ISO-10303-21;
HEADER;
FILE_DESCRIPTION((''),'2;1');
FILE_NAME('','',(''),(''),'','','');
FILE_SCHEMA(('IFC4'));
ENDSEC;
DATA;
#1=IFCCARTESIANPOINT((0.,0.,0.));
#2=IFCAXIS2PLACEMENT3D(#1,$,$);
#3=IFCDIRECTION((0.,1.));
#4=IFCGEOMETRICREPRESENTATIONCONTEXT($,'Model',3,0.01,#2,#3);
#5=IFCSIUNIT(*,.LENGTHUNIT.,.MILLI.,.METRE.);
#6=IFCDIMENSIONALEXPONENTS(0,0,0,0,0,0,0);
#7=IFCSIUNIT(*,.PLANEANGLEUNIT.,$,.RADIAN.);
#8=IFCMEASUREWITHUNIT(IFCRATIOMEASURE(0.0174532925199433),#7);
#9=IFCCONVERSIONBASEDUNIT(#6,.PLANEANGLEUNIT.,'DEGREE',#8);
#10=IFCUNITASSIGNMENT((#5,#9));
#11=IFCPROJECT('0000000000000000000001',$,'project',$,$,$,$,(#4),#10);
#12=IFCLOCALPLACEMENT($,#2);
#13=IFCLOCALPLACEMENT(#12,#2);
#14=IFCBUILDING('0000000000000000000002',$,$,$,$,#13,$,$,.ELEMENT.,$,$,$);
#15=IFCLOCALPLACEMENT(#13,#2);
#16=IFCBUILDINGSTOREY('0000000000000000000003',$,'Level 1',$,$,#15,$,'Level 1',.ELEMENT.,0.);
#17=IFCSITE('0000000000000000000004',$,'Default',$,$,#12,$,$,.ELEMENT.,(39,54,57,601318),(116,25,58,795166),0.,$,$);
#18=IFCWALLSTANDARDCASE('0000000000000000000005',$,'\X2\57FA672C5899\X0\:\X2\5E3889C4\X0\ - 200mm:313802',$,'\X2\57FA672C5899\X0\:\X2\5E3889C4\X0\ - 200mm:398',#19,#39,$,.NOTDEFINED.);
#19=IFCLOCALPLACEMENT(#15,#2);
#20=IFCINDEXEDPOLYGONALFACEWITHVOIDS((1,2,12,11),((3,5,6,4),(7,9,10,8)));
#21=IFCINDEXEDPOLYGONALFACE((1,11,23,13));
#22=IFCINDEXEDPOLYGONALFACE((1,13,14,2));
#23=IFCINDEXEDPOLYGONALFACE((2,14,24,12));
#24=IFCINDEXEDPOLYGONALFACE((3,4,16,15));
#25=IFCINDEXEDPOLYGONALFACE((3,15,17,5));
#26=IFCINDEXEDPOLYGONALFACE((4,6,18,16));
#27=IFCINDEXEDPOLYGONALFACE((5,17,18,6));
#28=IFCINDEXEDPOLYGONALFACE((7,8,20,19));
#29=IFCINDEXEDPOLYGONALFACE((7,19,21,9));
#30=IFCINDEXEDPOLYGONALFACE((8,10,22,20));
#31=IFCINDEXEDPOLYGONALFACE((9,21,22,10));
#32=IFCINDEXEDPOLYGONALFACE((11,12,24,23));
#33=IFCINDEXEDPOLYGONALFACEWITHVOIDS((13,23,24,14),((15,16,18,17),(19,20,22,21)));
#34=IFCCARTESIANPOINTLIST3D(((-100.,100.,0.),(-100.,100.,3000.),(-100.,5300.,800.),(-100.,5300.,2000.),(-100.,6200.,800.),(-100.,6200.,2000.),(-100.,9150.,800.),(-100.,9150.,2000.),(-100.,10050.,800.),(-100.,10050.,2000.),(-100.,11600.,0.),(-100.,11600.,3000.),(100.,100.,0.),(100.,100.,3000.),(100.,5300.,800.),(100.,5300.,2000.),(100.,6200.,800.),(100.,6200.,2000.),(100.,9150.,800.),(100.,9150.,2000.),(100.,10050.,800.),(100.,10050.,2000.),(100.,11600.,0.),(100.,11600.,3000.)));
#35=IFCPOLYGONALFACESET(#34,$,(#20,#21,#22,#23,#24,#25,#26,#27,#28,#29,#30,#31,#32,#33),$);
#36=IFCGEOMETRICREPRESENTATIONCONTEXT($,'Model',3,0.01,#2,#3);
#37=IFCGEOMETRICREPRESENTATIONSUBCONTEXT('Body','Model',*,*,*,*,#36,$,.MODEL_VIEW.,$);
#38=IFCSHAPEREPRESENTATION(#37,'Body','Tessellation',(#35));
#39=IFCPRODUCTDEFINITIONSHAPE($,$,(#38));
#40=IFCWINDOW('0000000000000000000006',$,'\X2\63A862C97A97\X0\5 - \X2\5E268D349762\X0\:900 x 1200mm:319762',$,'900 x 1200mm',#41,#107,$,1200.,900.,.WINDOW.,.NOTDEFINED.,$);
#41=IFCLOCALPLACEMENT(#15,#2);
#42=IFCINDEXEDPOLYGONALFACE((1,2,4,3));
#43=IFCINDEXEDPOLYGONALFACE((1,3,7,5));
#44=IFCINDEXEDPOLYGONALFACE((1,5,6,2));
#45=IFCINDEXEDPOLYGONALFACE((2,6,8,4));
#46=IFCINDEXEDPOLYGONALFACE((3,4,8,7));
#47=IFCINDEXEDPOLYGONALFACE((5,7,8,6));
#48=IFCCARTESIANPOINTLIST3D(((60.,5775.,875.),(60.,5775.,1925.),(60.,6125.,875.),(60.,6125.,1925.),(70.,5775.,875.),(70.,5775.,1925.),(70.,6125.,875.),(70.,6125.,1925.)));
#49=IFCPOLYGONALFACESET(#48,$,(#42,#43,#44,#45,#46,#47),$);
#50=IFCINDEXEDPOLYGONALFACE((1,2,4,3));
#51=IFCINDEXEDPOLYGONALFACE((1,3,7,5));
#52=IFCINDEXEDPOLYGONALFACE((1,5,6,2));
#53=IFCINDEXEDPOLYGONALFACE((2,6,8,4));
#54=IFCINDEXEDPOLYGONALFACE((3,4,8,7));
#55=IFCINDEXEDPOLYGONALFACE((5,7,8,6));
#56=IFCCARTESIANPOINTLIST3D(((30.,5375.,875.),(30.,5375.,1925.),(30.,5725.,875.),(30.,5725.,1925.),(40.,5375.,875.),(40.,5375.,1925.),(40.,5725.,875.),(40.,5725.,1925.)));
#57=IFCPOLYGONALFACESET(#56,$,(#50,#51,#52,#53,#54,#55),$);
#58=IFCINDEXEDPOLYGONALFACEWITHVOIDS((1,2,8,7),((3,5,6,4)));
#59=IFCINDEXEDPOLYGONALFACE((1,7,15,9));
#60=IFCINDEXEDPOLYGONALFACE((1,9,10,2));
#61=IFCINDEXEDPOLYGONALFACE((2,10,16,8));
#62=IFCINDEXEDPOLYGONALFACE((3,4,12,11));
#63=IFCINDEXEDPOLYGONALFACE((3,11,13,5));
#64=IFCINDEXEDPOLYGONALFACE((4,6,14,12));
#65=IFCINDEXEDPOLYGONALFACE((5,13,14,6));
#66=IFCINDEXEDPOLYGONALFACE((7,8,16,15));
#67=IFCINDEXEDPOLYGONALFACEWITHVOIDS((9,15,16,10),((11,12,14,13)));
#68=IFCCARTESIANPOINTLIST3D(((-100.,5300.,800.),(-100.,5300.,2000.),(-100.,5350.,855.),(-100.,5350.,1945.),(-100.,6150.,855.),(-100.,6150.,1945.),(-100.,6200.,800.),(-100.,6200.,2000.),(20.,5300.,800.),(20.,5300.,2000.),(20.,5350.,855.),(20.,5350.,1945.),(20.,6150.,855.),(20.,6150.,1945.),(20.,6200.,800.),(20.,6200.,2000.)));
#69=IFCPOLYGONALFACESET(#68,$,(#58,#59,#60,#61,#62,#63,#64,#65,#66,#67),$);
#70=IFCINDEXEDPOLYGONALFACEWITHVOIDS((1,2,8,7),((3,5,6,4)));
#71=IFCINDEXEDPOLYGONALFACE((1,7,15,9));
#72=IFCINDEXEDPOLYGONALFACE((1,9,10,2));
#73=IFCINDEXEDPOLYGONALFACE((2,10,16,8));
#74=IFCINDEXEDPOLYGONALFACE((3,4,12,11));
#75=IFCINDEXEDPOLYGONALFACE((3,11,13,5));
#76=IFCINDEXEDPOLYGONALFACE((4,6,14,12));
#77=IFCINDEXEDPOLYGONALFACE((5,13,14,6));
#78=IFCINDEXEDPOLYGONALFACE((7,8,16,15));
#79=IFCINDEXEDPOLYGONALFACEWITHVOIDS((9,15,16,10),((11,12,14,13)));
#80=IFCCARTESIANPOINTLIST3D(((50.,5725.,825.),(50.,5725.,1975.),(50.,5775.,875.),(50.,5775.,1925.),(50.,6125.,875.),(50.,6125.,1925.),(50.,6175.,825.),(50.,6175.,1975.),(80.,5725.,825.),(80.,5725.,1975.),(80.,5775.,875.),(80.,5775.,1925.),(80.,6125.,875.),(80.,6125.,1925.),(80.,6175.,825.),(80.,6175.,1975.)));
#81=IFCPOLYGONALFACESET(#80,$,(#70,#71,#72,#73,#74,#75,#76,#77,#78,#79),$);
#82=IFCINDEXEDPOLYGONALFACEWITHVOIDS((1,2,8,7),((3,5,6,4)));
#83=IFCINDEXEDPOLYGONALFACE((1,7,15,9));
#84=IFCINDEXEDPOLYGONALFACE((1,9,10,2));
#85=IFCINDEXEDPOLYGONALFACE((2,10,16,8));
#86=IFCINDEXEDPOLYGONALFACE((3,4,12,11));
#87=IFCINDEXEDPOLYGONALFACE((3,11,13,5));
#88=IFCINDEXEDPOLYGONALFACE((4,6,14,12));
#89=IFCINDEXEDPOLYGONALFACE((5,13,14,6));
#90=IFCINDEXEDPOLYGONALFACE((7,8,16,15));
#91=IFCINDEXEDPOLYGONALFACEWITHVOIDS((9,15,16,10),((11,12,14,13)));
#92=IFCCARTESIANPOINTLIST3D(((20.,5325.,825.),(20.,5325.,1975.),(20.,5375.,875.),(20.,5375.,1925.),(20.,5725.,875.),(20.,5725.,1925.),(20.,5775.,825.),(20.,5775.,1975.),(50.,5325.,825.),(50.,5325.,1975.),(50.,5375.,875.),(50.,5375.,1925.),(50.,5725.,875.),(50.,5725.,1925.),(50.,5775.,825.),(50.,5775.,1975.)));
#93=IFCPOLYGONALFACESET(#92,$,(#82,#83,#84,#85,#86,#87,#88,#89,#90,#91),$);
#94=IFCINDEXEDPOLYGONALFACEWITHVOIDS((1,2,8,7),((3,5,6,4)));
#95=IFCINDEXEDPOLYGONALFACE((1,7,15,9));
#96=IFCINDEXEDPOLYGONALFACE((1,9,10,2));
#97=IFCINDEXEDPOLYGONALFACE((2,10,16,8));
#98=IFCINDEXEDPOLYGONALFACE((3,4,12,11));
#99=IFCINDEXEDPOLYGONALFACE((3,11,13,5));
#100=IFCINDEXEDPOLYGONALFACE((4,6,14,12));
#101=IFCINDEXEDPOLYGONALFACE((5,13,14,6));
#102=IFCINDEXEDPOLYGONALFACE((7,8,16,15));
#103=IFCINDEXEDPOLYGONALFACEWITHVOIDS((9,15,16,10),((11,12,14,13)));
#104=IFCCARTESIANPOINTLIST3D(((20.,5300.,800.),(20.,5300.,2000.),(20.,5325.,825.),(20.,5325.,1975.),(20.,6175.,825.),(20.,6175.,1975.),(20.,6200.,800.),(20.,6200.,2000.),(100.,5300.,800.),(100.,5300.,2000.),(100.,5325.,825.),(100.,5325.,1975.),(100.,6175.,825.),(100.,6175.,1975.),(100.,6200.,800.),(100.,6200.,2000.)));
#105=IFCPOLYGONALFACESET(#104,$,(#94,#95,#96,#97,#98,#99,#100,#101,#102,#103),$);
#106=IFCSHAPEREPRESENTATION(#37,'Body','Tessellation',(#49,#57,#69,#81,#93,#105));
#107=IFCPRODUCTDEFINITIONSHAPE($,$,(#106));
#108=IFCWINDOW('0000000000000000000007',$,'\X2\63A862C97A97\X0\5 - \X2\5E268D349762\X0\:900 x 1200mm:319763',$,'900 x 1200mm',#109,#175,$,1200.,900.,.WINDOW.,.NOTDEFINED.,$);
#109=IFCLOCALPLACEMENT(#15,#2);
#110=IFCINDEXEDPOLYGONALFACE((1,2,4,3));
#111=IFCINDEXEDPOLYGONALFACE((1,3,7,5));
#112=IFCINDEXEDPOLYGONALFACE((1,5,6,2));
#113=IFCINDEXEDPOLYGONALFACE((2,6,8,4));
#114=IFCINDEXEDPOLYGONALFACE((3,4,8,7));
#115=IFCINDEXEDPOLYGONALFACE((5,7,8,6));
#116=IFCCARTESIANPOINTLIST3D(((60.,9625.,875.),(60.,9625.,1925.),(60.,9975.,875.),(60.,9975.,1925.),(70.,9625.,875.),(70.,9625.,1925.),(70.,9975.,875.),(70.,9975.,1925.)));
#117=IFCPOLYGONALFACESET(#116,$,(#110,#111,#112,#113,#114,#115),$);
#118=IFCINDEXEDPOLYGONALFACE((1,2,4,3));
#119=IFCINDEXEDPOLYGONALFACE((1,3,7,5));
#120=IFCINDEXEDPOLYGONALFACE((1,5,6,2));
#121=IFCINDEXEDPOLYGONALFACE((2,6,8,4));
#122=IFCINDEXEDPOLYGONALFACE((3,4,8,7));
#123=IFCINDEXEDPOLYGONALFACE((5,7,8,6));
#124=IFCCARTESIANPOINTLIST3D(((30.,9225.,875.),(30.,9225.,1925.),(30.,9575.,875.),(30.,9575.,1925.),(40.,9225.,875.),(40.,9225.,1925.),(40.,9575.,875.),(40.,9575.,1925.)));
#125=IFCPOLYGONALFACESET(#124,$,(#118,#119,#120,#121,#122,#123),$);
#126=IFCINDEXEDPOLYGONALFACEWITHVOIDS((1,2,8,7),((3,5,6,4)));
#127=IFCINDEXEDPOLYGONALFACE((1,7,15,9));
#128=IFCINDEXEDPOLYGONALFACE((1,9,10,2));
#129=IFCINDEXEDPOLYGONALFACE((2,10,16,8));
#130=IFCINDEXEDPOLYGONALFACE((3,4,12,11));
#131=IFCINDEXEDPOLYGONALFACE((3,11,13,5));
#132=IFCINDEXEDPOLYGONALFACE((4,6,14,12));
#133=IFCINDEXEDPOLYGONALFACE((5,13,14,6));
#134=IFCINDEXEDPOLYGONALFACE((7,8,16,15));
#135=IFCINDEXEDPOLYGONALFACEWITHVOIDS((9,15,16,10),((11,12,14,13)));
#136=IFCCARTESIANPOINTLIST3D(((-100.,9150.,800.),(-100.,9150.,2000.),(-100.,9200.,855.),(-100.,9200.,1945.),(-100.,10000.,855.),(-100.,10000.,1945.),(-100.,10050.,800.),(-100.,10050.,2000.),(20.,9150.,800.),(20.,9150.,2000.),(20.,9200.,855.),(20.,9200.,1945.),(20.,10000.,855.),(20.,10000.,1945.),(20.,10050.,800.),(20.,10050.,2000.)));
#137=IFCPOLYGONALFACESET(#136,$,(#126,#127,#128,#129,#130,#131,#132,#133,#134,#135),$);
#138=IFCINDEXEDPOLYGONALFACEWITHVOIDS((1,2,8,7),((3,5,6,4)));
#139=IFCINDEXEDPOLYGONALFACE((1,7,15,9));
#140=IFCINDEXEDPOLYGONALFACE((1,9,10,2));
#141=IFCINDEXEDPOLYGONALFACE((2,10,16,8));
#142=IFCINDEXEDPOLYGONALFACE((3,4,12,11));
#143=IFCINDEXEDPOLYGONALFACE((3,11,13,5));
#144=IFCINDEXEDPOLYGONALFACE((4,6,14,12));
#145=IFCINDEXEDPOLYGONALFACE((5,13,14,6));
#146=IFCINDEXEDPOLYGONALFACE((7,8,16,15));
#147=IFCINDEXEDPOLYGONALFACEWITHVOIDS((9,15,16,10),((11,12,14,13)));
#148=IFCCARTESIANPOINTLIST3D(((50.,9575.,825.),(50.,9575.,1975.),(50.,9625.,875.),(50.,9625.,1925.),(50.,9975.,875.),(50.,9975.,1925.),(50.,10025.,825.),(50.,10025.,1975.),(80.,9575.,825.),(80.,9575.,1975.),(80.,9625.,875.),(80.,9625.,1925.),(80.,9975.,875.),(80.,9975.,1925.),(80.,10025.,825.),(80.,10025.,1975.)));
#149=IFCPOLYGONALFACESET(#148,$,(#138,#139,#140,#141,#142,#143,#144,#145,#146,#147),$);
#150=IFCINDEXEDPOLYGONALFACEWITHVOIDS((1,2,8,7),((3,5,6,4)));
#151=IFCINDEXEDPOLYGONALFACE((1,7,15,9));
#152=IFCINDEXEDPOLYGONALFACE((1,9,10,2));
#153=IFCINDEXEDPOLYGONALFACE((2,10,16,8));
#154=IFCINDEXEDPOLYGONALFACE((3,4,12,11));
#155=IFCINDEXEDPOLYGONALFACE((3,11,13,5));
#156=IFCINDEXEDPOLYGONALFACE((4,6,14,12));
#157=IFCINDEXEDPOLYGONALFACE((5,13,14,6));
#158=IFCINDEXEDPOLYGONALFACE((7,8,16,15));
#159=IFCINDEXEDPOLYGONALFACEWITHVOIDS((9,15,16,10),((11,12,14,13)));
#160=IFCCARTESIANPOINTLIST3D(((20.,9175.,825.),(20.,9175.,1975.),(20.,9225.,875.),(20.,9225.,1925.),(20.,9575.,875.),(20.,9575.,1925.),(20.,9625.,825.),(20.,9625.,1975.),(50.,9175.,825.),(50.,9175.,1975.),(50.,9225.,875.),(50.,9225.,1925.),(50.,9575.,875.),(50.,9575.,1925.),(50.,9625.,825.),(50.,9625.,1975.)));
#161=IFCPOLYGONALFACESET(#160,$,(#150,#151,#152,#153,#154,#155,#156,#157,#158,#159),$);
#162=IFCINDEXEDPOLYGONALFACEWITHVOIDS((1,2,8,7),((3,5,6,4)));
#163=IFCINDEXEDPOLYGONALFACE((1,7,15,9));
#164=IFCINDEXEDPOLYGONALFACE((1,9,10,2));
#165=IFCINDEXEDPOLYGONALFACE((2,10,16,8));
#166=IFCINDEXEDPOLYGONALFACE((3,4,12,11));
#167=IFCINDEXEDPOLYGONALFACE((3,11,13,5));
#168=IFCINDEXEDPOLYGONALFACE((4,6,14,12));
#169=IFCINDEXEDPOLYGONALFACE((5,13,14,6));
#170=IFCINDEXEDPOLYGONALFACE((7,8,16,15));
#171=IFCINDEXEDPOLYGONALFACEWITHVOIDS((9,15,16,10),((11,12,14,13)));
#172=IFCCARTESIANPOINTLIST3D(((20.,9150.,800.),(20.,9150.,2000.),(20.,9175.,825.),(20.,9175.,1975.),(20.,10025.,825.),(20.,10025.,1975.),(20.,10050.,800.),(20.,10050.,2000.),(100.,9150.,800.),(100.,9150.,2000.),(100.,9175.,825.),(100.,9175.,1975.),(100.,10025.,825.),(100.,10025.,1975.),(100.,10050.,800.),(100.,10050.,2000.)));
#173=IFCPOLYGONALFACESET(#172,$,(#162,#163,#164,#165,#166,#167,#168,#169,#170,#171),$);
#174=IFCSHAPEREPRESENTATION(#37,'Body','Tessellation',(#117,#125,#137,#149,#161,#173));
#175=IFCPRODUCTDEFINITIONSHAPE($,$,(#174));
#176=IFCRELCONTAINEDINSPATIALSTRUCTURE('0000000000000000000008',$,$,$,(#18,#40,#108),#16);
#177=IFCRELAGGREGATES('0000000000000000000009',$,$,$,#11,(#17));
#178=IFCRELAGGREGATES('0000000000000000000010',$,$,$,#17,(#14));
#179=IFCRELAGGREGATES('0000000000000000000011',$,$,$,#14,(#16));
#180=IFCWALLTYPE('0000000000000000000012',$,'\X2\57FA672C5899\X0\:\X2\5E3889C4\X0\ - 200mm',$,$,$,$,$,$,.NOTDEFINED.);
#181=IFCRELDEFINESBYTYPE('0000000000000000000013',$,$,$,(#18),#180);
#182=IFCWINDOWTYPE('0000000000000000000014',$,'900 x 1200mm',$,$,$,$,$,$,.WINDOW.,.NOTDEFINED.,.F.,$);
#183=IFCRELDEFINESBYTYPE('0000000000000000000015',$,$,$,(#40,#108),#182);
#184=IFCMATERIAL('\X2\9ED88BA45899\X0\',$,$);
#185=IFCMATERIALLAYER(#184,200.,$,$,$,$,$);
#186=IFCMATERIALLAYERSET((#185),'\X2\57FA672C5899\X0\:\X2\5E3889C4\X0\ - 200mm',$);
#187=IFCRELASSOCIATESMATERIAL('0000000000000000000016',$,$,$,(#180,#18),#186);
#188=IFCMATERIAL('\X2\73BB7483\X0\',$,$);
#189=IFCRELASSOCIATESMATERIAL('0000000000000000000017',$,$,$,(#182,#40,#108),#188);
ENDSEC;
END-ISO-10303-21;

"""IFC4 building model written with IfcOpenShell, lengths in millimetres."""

from ifc_helpers import new_model, entity, si_unit, converted_unit, direction, frame, frame_2d, origin, origin_2d_with_axis, place, context, subcontext, project, spatial, polyline, rectangle, outline, extrude, source, transform, mapped, material, layer, layer_set, layer_usage, type_object, type_shapes, element, fill, save


model = new_model("IFC4")

# Units and contexts
model_context_1 = context("Model", 3, precision=0.01, world=origin(), true_north=direction((0.0, 1.0)))
model_context_2 = context("Model", 3, precision=0.01, world=origin(), true_north=direction((0.0, 1.0)))
body_context = subcontext(model_context_2, "Body", "Model", "MODEL_VIEW")
ifc_project = project(units=[si_unit("LENGTHUNIT", "METRE", prefix="MILLI"), converted_unit("PLANEANGLEUNIT", "DEGREE", entity("IfcRatioMeasure", 0.0174532925199433), si_unit("PLANEANGLEUNIT", "RADIAN"), dimensions=[0, 0, 0, 0, 0, 0, 0])], contexts=[model_context_1])

# Site, building, storey
site_placement = place(None, origin())
site = spatial("IfcSite", under=ifc_project, at=site_placement, Name="Default", CompositionType="ELEMENT", RefLatitude=(39, 54, 57, 601318), RefLongitude=(116, 25, 58, 795166), RefElevation=0.0)
building_placement = place(site_placement, origin())
building = spatial("IfcBuilding", under=site, at=building_placement, CompositionType="ELEMENT")
storey_placement = place(building_placement, origin())
storey = spatial("IfcBuildingStorey", under=building, at=storey_placement, Name="Level 1", LongName="Level 1", CompositionType="ELEMENT", Elevation=0.0)

# Shared definitions
ifc_material_1 = material(Name="默认墙")
ifc_layer = layer(ifc_material_1, 200.0)
ifc_layer_set = layer_set([ifc_layer], Name="基本墙:常规 - 200mm")
wall_type = type_object("IfcWallType", Name="基本墙:常规 - 200mm", PredefinedType="NOTDEFINED", material=ifc_layer_set)
ifc_material_2 = material(Name="玻璃")

# Wall, openings, windows
ifc_layer_usage_1 = layer_usage(ifc_layer_set, "AXIS2", "NEGATIVE", 100.0)
wall_1_placement = place(storey_placement, frame((0.0, 100.0, 0.0), z_axis=(0.0, 0.0, 1.0), x_axis=(0.0, 1.0, 0.0)))
wall_1 = element("IfcWallStandardCase", 1, at=wall_1_placement, inside=storey, type_object=wall_type, material=ifc_layer_usage_1, Name="基本墙:常规 - 200mm:313802", ObjectType="基本墙:常规 - 200mm:398", PredefinedType="NOTDEFINED", context=body_context, shape_type="SweptSolid", body=[
    extrude(rectangle(XDim=11500.0, YDim=200.0, at=frame_2d((5750.0, 0.0), x_axis=(-1.0, 0.0))), origin(), (0.0, 0.0, 1.0), 3000.0),
])
opening_1_placement = place(wall_1_placement, frame((6100.0, 100.0, 800.0)))
opening_1 = element("IfcOpeningElement", 2, at=opening_1_placement, cuts=wall_1, ObjectType="Opening", PredefinedType="OPENING", context=body_context, shape_type="SweptSolid", body=[
    extrude(rectangle(XDim=1200.0, YDim=900.0, at=frame_2d((600.0, 450.0), x_axis=(-1.0, 0.0))), frame((0.0, 0.0, 0.0), z_axis=(0.0, -1.0, 0.0), x_axis=(0.0, 0.0, 1.0)), (0.0, 0.0, 1.0), 200.0),
])
opening_2_placement = place(wall_1_placement, frame((9950.0, 100.0, 800.0)))
opening_2 = element("IfcOpeningElement", 3, at=opening_2_placement, cuts=wall_1, ObjectType="Opening", PredefinedType="OPENING", context=body_context, shape_type="SweptSolid", body=[
    extrude(rectangle(XDim=1200.0, YDim=900.0, at=frame_2d((600.0, 450.0), x_axis=(-1.0, 0.0))), frame((0.0, 0.0, 0.0), z_axis=(0.0, -1.0, 0.0), x_axis=(0.0, 0.0, 1.0)), (0.0, 0.0, 1.0), 200.0),
])
window_type_1 = type_object("IfcWindowType", Name="900 x 1200mm", ParameterTakesPrecedence=False, PartitioningType="NOTDEFINED", PredefinedType="WINDOW", material=ifc_material_2)
shared_shape_1 = source(origin(), body_context, "Body", "SweptSolid", [
    extrude(rectangle(XDim=10.0, YDim=350.0, at=origin_2d_with_axis()), frame((250.0, 165.0, 75.0), z_axis=(0.0, 0.0, 1.0), x_axis=(0.0, -1.0, 0.0)), (0.0, 0.0, 1.0), 1050.0),
    extrude(rectangle(XDim=10.0, YDim=350.0, at=origin_2d_with_axis()), frame((650.0, 135.0, 75.0), z_axis=(0.0, 0.0, 1.0), x_axis=(0.0, -1.0, 0.0)), (0.0, 0.0, 1.0), 1050.0),
    extrude(outline(polyline([(-450.0, -600.0), (450.0, -600.0), (450.0, 600.0), (-450.0, 600.0), (-450.0, -600.0)]), holes=[polyline([(400.0, -545.0), (-400.0, -545.0), (-400.0, 545.0), (400.0, 545.0), (400.0, -545.0)])]), frame((450.0, 0.0, 600.0), z_axis=(0.0, 1.0, 0.0), x_axis=(1.0, 0.0, 0.0)), (0.0, 0.0, 1.0), 120.0),
    extrude(outline(polyline([(-225.0, -575.0), (225.0, -575.0), (225.0, 575.0), (-225.0, 575.0), (-225.0, -575.0)]), holes=[polyline([(-175.0, -525.0), (-175.0, 525.0), (175.0, 525.0), (175.0, -525.0), (-175.0, -525.0)])]), frame((250.0, 150.0, 600.0), z_axis=(0.0, 1.0, 0.0), x_axis=(-1.0, 0.0, 0.0)), (0.0, 0.0, 1.0), 30.0),
    extrude(outline(polyline([(-225.0, -575.0), (225.0, -575.0), (225.0, 575.0), (-225.0, 575.0), (-225.0, -575.0)]), holes=[polyline([(-175.0, -525.0), (-175.0, 525.0), (175.0, 525.0), (175.0, -525.0), (-175.0, -525.0)])]), frame((650.0, 120.0, 600.0), z_axis=(0.0, 1.0, 0.0), x_axis=(1.0, 0.0, 0.0)), (0.0, 0.0, 1.0), 30.0),
    extrude(outline(polyline([(-450.0, -600.0), (450.0, -600.0), (450.0, 600.0), (-450.0, 600.0), (-450.0, -600.0)]), holes=[polyline([(-425.0, 575.0), (425.0, 575.0), (425.0, -575.0), (-425.0, -575.0), (-425.0, 575.0)])]), frame((450.0, 120.0, 600.0), z_axis=(0.0, 1.0, 0.0), x_axis=(1.0, 0.0, 0.0)), (0.0, 0.0, 1.0), 80.0),
])
type_shapes(window_type_1, [shared_shape_1])
window_1_placement = place(opening_1_placement, frame((0.0, 0.0, 0.0), z_axis=(0.0, 0.0, 1.0), x_axis=(-1.0, 0.0, 0.0)))
window_1 = element("IfcWindow", 4, at=window_1_placement, inside=storey, type_object=window_type_1, material=ifc_material_2, Name="推拉窗5 - 带贴面:900 x 1200mm:319762", ObjectType="900 x 1200mm", OverallHeight=1200.0, OverallWidth=900.0, PartitioningType="NOTDEFINED", PredefinedType="WINDOW", context=body_context, shape_type="MappedRepresentation", body=[
    mapped(shared_shape_1, transform((0.0, 0.0, 0.0), scale=1.0)),
])
fill(opening_1, window_1)
window_2_placement = place(opening_2_placement, frame((0.0, 0.0, 0.0), z_axis=(0.0, 0.0, 1.0), x_axis=(-1.0, 0.0, 0.0)))
window_2 = element("IfcWindow", 5, at=window_2_placement, inside=storey, type_object=window_type_1, material=ifc_material_2, Name="推拉窗5 - 带贴面:900 x 1200mm:319763", ObjectType="900 x 1200mm", OverallHeight=1200.0, OverallWidth=900.0, PartitioningType="NOTDEFINED", PredefinedType="WINDOW", context=body_context, shape_type="MappedRepresentation", body=[
    mapped(shared_shape_1, transform((0.0, 0.0, 0.0), scale=1.0)),
])
fill(opening_2, window_2)

save(model, "model.ifc")
